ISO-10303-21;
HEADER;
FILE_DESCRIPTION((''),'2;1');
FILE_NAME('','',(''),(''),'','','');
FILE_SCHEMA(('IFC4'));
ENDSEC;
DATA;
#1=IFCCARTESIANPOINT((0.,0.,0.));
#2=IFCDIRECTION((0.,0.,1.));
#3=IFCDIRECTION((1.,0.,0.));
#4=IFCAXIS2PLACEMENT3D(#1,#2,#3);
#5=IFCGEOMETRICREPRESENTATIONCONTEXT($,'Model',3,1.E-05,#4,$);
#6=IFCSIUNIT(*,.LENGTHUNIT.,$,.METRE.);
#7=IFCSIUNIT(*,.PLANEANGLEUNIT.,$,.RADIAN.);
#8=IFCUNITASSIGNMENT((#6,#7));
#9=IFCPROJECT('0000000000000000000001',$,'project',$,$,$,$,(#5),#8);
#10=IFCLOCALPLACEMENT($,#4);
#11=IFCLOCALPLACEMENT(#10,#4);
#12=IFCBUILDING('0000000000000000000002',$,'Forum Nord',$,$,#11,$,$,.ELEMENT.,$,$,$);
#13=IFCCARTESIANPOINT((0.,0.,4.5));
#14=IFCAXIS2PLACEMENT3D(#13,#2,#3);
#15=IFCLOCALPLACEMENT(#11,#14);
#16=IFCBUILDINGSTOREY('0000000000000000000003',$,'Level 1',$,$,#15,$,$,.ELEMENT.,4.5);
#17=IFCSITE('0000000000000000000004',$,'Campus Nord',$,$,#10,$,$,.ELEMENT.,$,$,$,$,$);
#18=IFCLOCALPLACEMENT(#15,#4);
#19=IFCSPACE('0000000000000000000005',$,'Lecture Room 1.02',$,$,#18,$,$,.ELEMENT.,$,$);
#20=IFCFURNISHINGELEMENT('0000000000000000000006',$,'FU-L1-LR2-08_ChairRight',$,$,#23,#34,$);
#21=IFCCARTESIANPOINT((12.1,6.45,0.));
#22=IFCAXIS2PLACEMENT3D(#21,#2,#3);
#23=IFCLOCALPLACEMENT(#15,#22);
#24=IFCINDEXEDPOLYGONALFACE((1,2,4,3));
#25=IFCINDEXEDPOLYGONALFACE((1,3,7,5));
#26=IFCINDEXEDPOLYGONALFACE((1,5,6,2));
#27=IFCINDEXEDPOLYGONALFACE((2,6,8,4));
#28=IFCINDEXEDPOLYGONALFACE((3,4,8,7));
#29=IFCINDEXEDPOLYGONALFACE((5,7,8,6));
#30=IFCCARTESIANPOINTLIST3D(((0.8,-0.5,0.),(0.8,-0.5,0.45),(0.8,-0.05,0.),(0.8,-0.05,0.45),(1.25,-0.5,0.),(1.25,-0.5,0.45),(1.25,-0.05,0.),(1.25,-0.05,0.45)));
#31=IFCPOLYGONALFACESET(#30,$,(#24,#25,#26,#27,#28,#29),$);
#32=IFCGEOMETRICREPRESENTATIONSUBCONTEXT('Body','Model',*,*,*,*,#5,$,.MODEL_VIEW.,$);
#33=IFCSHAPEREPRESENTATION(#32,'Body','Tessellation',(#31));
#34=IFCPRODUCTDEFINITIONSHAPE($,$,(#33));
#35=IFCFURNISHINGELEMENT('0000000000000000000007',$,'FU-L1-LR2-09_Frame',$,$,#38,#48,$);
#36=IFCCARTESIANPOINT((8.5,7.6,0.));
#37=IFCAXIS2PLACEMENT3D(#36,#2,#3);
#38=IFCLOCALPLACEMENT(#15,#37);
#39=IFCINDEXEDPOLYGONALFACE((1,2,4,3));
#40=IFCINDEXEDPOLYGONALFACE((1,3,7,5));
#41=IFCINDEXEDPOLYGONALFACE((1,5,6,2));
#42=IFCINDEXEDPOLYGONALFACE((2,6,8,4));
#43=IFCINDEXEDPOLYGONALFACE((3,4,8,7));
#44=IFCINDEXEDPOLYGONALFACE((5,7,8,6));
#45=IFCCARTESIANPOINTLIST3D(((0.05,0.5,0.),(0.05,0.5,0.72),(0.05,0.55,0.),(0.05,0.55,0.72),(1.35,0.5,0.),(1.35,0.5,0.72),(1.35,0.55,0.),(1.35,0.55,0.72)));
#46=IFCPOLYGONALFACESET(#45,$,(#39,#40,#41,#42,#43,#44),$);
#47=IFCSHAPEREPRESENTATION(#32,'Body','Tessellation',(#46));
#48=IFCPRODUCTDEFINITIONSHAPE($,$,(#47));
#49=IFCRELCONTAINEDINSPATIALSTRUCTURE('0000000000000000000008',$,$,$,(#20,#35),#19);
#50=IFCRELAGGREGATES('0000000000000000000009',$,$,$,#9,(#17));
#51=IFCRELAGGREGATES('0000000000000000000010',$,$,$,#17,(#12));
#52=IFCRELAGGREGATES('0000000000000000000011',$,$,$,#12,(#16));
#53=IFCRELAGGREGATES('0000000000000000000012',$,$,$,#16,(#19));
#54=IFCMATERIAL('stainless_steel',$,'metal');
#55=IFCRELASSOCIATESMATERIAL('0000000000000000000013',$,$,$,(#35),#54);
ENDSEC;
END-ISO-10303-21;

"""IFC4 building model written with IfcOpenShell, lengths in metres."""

from ifc_helpers import new_model, si_unit, frame, frame_2d, origin_with_axes, place, context, subcontext, project, spatial, rectangle, extrude, material, element, save


model = new_model("IFC4")

# Units and contexts
model_context = context("Model", 3, precision=1e-05, world=origin_with_axes())
body_context = subcontext(model_context, "Body", "Model", "MODEL_VIEW")
ifc_project = project(units=[si_unit("LENGTHUNIT", "METRE"), si_unit("PLANEANGLEUNIT", "RADIAN")], contexts=[model_context])

# Site, building, storey
site_placement = place(None, origin_with_axes())
site = spatial("IfcSite", under=ifc_project, at=site_placement, Name="Campus Nord", CompositionType="ELEMENT")
building_placement = place(site_placement, origin_with_axes())
building = spatial("IfcBuilding", under=site, at=building_placement, Name="Forum Nord", CompositionType="ELEMENT")
storey_placement = place(building_placement, frame((0.0, 0.0, 4.5), z_axis=(0.0, 0.0, 1.0), x_axis=(1.0, 0.0, 0.0)))
storey = spatial("IfcBuildingStorey", under=building, at=storey_placement, Name="Level 1", CompositionType="ELEMENT", Elevation=4.5)

# Shared definitions
ifc_material_1 = material(Name="stainless_steel", Category="metal")

# Shared definitions
space_1_placement = place(storey_placement, origin_with_axes())
space_1 = spatial("IfcSpace", under=storey, at=space_1_placement, Name="Lecture Room 1.02", CompositionType="ELEMENT")

# Furnishing elements
furnishing_1_placement = place(storey_placement, frame((12.1, 6.45, 0.0), z_axis=(0.0, 0.0, 1.0), x_axis=(1.0, 0.0, 0.0)))
element("IfcFurnishingElement", 1, at=furnishing_1_placement, inside=space_1, Name="FU-L1-LR2-08_ChairRight", context=body_context, shape_type="SweptSolid", body=[
    extrude(rectangle(XDim=0.45, YDim=0.45, at=frame_2d((1.025, -0.275), x_axis=(1.0, 0.0))), origin_with_axes(), (0.0, 0.0, 1.0), 0.45),
])
furnishing_2_placement = place(storey_placement, frame((8.5, 7.6, 0.0), z_axis=(0.0, 0.0, 1.0), x_axis=(1.0, 0.0, 0.0)))
element("IfcFurnishingElement", 2, at=furnishing_2_placement, inside=space_1, material=ifc_material_1, Name="FU-L1-LR2-09_Frame", context=body_context, shape_type="SweptSolid", body=[
    extrude(rectangle(XDim=1.3, YDim=0.05, at=frame_2d((0.7, 0.525), x_axis=(1.0, 0.0))), origin_with_axes(), (0.0, 0.0, 1.0), 0.72),
])

save(model, "model.ifc")
